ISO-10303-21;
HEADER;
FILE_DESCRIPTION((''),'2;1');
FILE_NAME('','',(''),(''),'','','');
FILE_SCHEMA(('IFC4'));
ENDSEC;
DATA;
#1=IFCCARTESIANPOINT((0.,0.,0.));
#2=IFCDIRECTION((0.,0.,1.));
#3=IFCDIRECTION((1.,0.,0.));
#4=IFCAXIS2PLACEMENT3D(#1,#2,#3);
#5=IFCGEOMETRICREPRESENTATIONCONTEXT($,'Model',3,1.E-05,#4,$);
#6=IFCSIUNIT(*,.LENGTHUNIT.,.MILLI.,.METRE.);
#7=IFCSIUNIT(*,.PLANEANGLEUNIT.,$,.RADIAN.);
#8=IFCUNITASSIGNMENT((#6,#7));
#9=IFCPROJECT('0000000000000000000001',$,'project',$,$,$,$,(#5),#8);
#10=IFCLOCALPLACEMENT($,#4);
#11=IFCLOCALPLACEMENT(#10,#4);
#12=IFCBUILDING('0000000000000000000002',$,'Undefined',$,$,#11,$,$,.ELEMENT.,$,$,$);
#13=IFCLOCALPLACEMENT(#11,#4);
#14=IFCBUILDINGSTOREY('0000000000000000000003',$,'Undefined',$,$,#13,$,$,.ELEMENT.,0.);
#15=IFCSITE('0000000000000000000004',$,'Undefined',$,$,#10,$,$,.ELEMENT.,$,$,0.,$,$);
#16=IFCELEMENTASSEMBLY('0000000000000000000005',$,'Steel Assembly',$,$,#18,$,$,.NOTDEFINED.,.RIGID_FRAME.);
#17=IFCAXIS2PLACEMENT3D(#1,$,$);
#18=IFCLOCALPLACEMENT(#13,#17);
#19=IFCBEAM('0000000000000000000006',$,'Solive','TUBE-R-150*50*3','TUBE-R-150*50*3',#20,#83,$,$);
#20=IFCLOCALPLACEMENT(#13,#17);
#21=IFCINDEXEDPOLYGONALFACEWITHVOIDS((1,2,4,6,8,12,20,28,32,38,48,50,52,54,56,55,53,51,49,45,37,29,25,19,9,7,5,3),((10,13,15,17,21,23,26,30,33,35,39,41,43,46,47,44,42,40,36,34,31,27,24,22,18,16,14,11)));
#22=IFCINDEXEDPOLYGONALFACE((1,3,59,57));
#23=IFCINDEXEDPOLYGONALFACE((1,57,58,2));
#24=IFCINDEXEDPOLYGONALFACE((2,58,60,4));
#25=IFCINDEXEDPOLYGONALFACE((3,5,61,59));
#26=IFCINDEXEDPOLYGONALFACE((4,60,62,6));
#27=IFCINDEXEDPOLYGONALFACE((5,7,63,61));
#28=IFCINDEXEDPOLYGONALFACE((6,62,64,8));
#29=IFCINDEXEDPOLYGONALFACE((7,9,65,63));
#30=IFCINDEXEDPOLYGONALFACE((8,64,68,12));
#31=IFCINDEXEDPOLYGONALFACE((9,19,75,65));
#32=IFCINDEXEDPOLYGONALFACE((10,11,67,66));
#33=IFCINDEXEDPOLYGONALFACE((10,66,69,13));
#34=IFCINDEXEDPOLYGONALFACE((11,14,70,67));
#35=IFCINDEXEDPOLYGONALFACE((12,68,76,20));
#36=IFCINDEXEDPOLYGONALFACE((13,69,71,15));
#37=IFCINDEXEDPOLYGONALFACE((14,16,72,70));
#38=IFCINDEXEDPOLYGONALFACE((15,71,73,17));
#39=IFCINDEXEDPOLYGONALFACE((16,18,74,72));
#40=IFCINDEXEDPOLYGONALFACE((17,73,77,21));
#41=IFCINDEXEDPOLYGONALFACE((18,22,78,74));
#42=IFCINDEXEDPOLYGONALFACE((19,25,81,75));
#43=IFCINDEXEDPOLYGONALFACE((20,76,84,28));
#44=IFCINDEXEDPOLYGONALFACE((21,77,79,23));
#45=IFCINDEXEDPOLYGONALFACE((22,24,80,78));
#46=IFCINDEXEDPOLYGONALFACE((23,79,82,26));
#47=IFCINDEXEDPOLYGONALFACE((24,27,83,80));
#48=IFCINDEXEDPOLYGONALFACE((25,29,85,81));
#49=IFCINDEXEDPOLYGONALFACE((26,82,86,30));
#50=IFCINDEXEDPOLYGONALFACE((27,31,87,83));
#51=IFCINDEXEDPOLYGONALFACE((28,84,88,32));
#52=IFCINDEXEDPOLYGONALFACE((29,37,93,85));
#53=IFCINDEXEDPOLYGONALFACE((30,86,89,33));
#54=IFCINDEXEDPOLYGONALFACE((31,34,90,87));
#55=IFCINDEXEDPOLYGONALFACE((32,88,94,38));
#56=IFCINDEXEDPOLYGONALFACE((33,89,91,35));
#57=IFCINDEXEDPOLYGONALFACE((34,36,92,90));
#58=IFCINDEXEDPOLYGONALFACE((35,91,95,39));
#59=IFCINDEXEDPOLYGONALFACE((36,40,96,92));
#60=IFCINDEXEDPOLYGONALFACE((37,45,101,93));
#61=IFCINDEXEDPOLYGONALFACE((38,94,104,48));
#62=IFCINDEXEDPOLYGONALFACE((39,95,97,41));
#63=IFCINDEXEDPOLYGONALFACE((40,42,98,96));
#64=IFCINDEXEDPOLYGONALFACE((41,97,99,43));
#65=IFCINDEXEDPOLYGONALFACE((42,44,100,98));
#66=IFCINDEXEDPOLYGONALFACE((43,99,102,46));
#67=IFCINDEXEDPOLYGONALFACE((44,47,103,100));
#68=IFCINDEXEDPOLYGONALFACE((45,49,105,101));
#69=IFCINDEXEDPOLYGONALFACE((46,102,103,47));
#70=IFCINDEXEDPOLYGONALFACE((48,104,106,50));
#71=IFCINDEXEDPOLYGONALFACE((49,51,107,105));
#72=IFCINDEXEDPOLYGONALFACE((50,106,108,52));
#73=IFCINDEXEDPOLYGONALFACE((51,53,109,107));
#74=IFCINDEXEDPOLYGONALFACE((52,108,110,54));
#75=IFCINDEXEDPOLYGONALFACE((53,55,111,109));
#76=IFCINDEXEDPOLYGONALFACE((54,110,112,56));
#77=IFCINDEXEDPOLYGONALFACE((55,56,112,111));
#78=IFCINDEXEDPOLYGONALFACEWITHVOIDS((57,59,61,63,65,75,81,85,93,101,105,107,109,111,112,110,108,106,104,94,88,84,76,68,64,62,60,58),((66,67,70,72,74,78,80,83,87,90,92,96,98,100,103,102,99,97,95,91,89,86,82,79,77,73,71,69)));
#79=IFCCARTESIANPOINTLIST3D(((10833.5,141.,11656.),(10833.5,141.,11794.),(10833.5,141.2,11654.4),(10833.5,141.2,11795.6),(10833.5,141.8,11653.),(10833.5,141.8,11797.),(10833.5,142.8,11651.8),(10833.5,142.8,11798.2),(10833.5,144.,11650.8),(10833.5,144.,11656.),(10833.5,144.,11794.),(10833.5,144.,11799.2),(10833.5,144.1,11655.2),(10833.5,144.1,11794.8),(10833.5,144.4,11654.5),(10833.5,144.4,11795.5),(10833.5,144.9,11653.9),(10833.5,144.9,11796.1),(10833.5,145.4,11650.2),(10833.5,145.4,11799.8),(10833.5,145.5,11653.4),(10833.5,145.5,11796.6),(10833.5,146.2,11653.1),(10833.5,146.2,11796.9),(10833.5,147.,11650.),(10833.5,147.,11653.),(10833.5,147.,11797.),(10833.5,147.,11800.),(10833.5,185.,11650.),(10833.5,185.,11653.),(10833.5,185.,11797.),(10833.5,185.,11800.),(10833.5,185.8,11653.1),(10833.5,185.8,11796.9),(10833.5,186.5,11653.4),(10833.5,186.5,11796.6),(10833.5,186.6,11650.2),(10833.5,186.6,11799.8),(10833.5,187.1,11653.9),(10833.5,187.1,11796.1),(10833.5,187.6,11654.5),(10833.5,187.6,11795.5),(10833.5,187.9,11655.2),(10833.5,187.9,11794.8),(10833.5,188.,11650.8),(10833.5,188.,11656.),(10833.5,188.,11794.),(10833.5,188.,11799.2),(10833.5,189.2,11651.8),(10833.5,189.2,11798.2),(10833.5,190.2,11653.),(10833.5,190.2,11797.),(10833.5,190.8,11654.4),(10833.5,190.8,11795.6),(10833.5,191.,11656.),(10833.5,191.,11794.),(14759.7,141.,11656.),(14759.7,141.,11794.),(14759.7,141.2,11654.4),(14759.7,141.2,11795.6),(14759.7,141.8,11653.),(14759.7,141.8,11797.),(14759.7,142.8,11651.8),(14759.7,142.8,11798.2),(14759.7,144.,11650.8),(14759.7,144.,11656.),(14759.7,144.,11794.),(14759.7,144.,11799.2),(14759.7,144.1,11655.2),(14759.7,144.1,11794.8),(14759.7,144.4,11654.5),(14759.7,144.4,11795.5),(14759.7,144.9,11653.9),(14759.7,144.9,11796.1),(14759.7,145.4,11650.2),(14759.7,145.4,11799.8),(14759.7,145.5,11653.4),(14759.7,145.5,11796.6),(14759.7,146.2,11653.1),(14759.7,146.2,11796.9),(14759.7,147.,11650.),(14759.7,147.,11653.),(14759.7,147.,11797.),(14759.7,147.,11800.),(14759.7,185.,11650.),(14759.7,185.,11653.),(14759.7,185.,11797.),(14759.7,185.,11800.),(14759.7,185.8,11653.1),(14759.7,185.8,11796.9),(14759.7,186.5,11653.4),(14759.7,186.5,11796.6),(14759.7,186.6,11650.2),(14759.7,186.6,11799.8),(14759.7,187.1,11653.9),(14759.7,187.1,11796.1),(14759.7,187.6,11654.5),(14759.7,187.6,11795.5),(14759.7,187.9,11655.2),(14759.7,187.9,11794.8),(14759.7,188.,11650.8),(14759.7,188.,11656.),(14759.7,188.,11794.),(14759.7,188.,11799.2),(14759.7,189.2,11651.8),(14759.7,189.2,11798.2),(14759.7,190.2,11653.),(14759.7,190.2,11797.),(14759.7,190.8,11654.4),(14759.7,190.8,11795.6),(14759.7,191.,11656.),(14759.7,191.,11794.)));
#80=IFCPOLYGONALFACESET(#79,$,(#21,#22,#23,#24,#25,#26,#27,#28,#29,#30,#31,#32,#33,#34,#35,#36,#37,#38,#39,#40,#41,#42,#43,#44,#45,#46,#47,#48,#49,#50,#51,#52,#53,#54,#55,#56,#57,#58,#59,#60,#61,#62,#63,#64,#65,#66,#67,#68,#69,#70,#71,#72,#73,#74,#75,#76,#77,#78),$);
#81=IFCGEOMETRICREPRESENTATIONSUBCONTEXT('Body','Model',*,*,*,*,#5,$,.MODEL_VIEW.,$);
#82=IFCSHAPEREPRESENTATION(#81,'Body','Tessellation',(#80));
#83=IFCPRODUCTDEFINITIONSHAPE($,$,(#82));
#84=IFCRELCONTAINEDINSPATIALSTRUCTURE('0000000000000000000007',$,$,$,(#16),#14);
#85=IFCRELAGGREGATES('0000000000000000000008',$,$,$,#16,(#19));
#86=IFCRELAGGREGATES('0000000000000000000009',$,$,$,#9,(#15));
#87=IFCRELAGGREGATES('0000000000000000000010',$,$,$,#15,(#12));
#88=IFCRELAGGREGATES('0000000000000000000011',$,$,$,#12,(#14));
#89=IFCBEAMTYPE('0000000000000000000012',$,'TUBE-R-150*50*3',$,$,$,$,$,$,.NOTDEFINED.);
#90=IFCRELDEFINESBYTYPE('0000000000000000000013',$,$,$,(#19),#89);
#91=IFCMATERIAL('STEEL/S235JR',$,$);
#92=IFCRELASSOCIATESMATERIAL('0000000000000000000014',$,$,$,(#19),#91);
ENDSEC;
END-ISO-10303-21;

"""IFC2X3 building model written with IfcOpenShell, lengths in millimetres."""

from ifc_helpers import new_model, si_unit, frame, origin_with_axes, origin_2d_with_axis, place, context, subcontext, project, spatial, hollow_rectangle, extrude, material, type_object, element, aggregate, save


model = new_model("IFC2X3")

# Units and contexts
model_context = context("Model", 3, precision=1e-05, world=origin_with_axes())
body_context = subcontext(model_context, "Body", "Model", "MODEL_VIEW")
ifc_project = project(units=[si_unit("LENGTHUNIT", "METRE", prefix="MILLI"), si_unit("PLANEANGLEUNIT", "RADIAN")], contexts=[model_context])

# Site, building, storey
site_placement = place(None, origin_with_axes())
site = spatial("IfcSite", under=ifc_project, at=site_placement, Name="Undefined", CompositionType="ELEMENT", RefElevation=0.0)
building_placement = place(site_placement, origin_with_axes())
building = spatial("IfcBuilding", under=site, at=building_placement, Name="Undefined", CompositionType="ELEMENT")
storey_placement = place(building_placement, origin_with_axes())
storey = spatial("IfcBuildingStorey", under=building, at=storey_placement, Name="Undefined", CompositionType="ELEMENT", Elevation=0.0)

# Element assembly, beam
ifc_material_1 = material(Name="STEEL/S235JR")
beam_type_1 = type_object("IfcBeamType", Name="TUBE-R-150*50*3", PredefinedType="NOTDEFINED")
assembly_1_placement = place(storey_placement, origin_with_axes())
assembly_1 = element("IfcElementAssembly", 1, at=assembly_1_placement, inside=storey, Name="Steel Assembly", AssemblyPlace="NOTDEFINED", PredefinedType="RIGID_FRAME")
beam_1_placement = place(assembly_1_placement, frame((14759.7, 166.0, 11725.0), z_axis=(0.0, 0.0, 1.0), x_axis=(-1.0, 0.0, 0.0)))
beam_1 = element("IfcBeam", 2, at=beam_1_placement, type_object=beam_type_1, material=ifc_material_1, Name="Solive", Description="TUBE-R-150*50*3", ObjectType="TUBE-R-150*50*3", context=body_context, shape_type="SweptSolid", body=[
    extrude(hollow_rectangle(XDim=50.0, YDim=150.0, WallThickness=3.0, InnerFilletRadius=3.0, OuterFilletRadius=6.0, at=origin_2d_with_axis()), frame((3926.2, 0.0, 0.0), z_axis=(-1.0, 0.0, 0.0), x_axis=(0.0, -1.0, 0.0)), (0.0, 0.0, 1.0), 3926.2),
])
aggregate(assembly_1, [beam_1])

save(model, "model.ifc")
